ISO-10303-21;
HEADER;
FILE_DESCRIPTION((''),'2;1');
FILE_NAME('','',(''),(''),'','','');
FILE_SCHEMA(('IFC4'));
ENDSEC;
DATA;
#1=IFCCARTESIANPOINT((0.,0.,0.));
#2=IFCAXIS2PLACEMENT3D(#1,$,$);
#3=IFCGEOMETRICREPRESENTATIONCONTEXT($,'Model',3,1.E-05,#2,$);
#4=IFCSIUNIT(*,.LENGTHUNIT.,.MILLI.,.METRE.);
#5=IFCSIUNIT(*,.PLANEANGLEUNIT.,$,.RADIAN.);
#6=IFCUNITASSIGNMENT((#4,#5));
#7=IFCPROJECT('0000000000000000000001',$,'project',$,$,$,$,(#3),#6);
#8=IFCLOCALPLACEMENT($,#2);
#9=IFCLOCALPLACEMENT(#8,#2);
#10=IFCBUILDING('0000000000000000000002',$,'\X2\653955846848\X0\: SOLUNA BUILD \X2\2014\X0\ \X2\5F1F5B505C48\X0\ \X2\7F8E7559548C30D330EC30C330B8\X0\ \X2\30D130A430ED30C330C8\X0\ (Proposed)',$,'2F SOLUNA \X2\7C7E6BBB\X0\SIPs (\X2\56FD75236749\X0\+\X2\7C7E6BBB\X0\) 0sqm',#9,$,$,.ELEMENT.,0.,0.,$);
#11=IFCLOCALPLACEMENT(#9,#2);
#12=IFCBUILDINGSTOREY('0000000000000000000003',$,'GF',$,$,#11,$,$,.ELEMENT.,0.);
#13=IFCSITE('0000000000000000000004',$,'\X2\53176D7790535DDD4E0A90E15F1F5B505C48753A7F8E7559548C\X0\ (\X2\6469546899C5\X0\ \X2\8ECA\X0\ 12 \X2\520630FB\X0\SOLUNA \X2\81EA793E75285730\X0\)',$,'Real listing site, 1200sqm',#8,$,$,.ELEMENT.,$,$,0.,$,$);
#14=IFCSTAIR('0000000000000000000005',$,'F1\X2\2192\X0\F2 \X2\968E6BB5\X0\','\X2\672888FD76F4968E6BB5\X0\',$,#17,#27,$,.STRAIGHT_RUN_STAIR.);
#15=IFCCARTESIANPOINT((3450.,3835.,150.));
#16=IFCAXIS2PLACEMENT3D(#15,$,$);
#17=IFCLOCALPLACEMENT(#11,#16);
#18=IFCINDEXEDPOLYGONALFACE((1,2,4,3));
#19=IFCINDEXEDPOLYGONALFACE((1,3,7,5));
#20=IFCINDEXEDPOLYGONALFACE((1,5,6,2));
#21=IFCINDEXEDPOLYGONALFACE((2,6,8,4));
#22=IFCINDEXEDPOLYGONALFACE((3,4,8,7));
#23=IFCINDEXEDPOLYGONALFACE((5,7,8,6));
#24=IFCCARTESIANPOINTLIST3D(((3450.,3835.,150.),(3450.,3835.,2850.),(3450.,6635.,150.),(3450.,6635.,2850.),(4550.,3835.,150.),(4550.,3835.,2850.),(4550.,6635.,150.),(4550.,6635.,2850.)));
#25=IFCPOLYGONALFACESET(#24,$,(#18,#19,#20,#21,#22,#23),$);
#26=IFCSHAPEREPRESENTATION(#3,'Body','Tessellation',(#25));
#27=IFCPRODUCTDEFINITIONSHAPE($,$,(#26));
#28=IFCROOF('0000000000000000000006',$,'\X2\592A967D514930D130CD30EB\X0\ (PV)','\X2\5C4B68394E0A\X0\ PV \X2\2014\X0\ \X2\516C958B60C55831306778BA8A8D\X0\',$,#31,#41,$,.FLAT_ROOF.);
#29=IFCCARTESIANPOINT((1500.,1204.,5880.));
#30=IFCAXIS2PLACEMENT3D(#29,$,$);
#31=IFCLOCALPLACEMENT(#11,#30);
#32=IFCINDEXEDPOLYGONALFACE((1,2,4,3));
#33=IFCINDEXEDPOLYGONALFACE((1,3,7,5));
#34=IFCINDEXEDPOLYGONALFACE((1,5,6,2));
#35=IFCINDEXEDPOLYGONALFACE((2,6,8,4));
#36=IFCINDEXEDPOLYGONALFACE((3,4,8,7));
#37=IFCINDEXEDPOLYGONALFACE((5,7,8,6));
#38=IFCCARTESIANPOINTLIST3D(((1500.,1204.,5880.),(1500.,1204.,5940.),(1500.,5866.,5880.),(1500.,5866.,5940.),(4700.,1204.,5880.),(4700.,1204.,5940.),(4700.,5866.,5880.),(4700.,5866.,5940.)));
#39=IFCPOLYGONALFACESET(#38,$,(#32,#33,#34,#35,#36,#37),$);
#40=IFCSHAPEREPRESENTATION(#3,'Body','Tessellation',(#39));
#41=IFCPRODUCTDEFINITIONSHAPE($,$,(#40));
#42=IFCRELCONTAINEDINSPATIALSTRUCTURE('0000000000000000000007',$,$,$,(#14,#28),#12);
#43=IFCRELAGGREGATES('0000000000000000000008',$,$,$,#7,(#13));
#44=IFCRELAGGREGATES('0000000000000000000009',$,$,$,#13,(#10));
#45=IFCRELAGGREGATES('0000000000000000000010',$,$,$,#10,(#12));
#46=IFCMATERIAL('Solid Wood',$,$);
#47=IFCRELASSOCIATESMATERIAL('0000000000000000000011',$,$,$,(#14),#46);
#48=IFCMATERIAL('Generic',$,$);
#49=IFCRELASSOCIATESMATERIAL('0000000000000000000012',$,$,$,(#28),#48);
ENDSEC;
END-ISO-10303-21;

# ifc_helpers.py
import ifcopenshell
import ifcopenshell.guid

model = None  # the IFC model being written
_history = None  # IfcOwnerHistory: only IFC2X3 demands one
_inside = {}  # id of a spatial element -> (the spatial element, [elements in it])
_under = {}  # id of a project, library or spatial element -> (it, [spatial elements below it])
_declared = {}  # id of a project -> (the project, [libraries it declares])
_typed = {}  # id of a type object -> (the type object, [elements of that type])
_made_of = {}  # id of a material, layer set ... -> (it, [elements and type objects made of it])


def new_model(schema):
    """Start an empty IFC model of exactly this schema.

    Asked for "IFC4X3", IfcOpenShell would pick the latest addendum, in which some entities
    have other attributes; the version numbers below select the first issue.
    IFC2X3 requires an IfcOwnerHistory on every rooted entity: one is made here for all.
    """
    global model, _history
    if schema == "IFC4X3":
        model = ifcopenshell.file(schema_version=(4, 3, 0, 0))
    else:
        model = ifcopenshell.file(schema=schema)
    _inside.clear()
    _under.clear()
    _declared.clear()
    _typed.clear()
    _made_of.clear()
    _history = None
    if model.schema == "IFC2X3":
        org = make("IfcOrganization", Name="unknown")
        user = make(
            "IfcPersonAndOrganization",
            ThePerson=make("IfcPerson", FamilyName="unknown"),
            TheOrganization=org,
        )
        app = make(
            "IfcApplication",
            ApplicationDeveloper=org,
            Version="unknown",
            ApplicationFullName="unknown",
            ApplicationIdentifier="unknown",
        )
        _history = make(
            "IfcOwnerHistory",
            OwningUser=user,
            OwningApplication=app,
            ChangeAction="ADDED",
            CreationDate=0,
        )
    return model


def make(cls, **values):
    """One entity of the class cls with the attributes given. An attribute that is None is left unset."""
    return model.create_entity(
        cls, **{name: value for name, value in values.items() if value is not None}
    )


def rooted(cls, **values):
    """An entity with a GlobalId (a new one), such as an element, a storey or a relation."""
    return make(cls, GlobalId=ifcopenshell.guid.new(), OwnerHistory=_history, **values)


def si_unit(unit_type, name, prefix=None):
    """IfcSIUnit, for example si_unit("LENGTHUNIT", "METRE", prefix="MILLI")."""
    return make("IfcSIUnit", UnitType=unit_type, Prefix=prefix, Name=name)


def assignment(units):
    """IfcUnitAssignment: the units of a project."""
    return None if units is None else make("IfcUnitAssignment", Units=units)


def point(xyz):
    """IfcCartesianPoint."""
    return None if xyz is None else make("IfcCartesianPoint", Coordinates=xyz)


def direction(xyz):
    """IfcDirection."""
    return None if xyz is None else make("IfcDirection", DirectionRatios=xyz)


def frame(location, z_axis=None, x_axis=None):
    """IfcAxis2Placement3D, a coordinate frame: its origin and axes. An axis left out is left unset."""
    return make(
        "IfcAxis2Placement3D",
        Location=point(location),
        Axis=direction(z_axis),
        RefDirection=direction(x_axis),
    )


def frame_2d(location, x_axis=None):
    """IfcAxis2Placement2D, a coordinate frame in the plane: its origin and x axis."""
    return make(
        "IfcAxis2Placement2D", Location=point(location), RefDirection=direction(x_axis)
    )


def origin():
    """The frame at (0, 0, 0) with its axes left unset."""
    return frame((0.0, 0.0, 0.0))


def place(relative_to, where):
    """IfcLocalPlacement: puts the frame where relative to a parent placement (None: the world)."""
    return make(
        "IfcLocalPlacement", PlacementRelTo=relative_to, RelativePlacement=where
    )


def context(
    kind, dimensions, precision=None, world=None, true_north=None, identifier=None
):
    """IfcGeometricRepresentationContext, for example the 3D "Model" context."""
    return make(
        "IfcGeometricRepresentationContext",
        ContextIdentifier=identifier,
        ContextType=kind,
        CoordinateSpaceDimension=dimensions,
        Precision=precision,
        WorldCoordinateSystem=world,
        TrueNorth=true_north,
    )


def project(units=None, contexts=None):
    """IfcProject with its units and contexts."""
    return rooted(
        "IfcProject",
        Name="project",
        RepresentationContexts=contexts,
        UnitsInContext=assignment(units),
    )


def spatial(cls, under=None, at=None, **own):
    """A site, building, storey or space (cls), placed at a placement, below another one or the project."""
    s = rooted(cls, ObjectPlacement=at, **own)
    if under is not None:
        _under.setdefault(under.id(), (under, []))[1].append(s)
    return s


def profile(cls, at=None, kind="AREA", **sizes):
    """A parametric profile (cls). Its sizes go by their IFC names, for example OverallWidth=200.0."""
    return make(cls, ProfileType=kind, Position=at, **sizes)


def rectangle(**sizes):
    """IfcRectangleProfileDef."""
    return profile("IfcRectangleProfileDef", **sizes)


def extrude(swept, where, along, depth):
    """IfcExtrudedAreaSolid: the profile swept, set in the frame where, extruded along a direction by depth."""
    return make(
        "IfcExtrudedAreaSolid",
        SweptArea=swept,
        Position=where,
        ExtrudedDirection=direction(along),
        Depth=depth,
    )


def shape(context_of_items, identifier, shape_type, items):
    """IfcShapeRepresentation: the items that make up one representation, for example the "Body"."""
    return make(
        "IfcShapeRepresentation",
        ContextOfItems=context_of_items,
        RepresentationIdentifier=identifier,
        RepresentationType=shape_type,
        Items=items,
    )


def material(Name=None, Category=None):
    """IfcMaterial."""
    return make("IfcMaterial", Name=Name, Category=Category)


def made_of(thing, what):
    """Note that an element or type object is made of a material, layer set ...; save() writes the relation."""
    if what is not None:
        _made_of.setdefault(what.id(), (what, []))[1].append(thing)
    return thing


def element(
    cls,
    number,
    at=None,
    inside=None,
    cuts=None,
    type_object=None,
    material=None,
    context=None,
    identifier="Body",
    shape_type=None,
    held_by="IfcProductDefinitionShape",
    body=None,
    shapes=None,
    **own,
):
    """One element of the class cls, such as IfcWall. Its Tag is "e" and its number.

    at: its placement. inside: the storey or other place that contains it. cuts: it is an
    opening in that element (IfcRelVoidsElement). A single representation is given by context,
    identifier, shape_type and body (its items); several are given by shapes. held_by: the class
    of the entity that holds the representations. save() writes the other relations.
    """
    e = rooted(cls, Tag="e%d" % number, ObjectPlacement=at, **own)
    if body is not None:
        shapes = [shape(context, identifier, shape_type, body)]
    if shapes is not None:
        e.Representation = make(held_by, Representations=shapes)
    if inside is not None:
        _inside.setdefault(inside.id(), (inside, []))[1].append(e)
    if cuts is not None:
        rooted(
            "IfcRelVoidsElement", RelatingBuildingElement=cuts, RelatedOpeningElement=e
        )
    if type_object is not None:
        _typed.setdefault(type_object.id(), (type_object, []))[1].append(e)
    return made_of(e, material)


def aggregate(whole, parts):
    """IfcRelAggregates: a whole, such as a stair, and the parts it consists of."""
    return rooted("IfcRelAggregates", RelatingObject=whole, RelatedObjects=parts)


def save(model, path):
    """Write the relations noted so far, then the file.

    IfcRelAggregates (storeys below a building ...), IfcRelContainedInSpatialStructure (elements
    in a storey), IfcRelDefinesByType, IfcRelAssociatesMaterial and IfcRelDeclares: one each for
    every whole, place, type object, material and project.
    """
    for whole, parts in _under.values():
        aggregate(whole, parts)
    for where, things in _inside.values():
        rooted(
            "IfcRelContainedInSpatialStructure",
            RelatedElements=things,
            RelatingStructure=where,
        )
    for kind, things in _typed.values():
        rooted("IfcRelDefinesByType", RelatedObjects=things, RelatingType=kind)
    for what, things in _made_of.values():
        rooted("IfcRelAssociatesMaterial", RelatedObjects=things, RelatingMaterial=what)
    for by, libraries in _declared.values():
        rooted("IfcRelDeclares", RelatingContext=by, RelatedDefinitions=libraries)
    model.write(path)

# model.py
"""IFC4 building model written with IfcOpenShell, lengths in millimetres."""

from ifc_helpers import new_model, si_unit, frame, frame_2d, origin, place, context, project, spatial, rectangle, extrude, material, element, save


model = new_model("IFC4")

# Units and contexts
model_context = context("Model", 3, precision=1e-05, world=origin())
ifc_project = project(units=[si_unit("LENGTHUNIT", "METRE", prefix="MILLI"), si_unit("PLANEANGLEUNIT", "RADIAN")], contexts=[model_context])

# Site, building, storey
site_placement = place(None, origin())
site = spatial("IfcSite", under=ifc_project, at=site_placement, Name="北海道川上郡弟子屈町美留和 (摩周駅 車 12 分・SOLUNA 自社用地)", ObjectType="Real listing site, 1200sqm", CompositionType="ELEMENT", RefElevation=0.0)
building_placement = place(site_placement, origin())
building = spatial("IfcBuilding", under=site, at=building_placement, Name="改善案: SOLUNA BUILD — 弟子屈 美留和ビレッジ パイロット (Proposed)", ObjectType="2F SOLUNA 籾殻SIPs (国産杉+籾殻) 0sqm", CompositionType="ELEMENT", ElevationOfRefHeight=0.0, ElevationOfTerrain=0.0)
storey_placement = place(building_placement, origin())
storey = spatial("IfcBuildingStorey", under=building, at=storey_placement, Name="GF", CompositionType="ELEMENT", Elevation=0.0)

# Shared definitions
ifc_material_1 = material(Name="Generic")

# Stair
ifc_material_2 = material(Name="Solid Wood")
stair_placement = place(storey_placement, frame((3450.0, 3835.0, 150.0)))
element("IfcStair", 1, at=stair_placement, inside=storey, material=ifc_material_2, Name="F1→F2 階段", Description="木製直階段", PredefinedType="STRAIGHT_RUN_STAIR", context=model_context, shape_type="SweptSolid", body=[
    extrude(rectangle(XDim=1100.0, YDim=2800.0, at=frame_2d((550.0, 1400.0))), frame((3450.0, 3835.0, 150.0)), (0.0, 0.0, 1.0), 2700.0),
])

# Roof
roof_placement = place(storey_placement, frame((1500.0, 1204.0, 5880.0)))
element("IfcRoof", 2, at=roof_placement, inside=storey, material=ifc_material_1, Name="太陽光パネル (PV)", Description="屋根上 PV — 公開情報で確認", PredefinedType="FLAT_ROOF", context=model_context, shape_type="SweptSolid", body=[
    extrude(rectangle(XDim=3200.0, YDim=4662.0, at=frame_2d((1600.0, 2331.0))), frame((1500.0, 1204.0, 5880.0)), (0.0, 0.0, 1.0), 60.0),
])

save(model, "model.ifc")
